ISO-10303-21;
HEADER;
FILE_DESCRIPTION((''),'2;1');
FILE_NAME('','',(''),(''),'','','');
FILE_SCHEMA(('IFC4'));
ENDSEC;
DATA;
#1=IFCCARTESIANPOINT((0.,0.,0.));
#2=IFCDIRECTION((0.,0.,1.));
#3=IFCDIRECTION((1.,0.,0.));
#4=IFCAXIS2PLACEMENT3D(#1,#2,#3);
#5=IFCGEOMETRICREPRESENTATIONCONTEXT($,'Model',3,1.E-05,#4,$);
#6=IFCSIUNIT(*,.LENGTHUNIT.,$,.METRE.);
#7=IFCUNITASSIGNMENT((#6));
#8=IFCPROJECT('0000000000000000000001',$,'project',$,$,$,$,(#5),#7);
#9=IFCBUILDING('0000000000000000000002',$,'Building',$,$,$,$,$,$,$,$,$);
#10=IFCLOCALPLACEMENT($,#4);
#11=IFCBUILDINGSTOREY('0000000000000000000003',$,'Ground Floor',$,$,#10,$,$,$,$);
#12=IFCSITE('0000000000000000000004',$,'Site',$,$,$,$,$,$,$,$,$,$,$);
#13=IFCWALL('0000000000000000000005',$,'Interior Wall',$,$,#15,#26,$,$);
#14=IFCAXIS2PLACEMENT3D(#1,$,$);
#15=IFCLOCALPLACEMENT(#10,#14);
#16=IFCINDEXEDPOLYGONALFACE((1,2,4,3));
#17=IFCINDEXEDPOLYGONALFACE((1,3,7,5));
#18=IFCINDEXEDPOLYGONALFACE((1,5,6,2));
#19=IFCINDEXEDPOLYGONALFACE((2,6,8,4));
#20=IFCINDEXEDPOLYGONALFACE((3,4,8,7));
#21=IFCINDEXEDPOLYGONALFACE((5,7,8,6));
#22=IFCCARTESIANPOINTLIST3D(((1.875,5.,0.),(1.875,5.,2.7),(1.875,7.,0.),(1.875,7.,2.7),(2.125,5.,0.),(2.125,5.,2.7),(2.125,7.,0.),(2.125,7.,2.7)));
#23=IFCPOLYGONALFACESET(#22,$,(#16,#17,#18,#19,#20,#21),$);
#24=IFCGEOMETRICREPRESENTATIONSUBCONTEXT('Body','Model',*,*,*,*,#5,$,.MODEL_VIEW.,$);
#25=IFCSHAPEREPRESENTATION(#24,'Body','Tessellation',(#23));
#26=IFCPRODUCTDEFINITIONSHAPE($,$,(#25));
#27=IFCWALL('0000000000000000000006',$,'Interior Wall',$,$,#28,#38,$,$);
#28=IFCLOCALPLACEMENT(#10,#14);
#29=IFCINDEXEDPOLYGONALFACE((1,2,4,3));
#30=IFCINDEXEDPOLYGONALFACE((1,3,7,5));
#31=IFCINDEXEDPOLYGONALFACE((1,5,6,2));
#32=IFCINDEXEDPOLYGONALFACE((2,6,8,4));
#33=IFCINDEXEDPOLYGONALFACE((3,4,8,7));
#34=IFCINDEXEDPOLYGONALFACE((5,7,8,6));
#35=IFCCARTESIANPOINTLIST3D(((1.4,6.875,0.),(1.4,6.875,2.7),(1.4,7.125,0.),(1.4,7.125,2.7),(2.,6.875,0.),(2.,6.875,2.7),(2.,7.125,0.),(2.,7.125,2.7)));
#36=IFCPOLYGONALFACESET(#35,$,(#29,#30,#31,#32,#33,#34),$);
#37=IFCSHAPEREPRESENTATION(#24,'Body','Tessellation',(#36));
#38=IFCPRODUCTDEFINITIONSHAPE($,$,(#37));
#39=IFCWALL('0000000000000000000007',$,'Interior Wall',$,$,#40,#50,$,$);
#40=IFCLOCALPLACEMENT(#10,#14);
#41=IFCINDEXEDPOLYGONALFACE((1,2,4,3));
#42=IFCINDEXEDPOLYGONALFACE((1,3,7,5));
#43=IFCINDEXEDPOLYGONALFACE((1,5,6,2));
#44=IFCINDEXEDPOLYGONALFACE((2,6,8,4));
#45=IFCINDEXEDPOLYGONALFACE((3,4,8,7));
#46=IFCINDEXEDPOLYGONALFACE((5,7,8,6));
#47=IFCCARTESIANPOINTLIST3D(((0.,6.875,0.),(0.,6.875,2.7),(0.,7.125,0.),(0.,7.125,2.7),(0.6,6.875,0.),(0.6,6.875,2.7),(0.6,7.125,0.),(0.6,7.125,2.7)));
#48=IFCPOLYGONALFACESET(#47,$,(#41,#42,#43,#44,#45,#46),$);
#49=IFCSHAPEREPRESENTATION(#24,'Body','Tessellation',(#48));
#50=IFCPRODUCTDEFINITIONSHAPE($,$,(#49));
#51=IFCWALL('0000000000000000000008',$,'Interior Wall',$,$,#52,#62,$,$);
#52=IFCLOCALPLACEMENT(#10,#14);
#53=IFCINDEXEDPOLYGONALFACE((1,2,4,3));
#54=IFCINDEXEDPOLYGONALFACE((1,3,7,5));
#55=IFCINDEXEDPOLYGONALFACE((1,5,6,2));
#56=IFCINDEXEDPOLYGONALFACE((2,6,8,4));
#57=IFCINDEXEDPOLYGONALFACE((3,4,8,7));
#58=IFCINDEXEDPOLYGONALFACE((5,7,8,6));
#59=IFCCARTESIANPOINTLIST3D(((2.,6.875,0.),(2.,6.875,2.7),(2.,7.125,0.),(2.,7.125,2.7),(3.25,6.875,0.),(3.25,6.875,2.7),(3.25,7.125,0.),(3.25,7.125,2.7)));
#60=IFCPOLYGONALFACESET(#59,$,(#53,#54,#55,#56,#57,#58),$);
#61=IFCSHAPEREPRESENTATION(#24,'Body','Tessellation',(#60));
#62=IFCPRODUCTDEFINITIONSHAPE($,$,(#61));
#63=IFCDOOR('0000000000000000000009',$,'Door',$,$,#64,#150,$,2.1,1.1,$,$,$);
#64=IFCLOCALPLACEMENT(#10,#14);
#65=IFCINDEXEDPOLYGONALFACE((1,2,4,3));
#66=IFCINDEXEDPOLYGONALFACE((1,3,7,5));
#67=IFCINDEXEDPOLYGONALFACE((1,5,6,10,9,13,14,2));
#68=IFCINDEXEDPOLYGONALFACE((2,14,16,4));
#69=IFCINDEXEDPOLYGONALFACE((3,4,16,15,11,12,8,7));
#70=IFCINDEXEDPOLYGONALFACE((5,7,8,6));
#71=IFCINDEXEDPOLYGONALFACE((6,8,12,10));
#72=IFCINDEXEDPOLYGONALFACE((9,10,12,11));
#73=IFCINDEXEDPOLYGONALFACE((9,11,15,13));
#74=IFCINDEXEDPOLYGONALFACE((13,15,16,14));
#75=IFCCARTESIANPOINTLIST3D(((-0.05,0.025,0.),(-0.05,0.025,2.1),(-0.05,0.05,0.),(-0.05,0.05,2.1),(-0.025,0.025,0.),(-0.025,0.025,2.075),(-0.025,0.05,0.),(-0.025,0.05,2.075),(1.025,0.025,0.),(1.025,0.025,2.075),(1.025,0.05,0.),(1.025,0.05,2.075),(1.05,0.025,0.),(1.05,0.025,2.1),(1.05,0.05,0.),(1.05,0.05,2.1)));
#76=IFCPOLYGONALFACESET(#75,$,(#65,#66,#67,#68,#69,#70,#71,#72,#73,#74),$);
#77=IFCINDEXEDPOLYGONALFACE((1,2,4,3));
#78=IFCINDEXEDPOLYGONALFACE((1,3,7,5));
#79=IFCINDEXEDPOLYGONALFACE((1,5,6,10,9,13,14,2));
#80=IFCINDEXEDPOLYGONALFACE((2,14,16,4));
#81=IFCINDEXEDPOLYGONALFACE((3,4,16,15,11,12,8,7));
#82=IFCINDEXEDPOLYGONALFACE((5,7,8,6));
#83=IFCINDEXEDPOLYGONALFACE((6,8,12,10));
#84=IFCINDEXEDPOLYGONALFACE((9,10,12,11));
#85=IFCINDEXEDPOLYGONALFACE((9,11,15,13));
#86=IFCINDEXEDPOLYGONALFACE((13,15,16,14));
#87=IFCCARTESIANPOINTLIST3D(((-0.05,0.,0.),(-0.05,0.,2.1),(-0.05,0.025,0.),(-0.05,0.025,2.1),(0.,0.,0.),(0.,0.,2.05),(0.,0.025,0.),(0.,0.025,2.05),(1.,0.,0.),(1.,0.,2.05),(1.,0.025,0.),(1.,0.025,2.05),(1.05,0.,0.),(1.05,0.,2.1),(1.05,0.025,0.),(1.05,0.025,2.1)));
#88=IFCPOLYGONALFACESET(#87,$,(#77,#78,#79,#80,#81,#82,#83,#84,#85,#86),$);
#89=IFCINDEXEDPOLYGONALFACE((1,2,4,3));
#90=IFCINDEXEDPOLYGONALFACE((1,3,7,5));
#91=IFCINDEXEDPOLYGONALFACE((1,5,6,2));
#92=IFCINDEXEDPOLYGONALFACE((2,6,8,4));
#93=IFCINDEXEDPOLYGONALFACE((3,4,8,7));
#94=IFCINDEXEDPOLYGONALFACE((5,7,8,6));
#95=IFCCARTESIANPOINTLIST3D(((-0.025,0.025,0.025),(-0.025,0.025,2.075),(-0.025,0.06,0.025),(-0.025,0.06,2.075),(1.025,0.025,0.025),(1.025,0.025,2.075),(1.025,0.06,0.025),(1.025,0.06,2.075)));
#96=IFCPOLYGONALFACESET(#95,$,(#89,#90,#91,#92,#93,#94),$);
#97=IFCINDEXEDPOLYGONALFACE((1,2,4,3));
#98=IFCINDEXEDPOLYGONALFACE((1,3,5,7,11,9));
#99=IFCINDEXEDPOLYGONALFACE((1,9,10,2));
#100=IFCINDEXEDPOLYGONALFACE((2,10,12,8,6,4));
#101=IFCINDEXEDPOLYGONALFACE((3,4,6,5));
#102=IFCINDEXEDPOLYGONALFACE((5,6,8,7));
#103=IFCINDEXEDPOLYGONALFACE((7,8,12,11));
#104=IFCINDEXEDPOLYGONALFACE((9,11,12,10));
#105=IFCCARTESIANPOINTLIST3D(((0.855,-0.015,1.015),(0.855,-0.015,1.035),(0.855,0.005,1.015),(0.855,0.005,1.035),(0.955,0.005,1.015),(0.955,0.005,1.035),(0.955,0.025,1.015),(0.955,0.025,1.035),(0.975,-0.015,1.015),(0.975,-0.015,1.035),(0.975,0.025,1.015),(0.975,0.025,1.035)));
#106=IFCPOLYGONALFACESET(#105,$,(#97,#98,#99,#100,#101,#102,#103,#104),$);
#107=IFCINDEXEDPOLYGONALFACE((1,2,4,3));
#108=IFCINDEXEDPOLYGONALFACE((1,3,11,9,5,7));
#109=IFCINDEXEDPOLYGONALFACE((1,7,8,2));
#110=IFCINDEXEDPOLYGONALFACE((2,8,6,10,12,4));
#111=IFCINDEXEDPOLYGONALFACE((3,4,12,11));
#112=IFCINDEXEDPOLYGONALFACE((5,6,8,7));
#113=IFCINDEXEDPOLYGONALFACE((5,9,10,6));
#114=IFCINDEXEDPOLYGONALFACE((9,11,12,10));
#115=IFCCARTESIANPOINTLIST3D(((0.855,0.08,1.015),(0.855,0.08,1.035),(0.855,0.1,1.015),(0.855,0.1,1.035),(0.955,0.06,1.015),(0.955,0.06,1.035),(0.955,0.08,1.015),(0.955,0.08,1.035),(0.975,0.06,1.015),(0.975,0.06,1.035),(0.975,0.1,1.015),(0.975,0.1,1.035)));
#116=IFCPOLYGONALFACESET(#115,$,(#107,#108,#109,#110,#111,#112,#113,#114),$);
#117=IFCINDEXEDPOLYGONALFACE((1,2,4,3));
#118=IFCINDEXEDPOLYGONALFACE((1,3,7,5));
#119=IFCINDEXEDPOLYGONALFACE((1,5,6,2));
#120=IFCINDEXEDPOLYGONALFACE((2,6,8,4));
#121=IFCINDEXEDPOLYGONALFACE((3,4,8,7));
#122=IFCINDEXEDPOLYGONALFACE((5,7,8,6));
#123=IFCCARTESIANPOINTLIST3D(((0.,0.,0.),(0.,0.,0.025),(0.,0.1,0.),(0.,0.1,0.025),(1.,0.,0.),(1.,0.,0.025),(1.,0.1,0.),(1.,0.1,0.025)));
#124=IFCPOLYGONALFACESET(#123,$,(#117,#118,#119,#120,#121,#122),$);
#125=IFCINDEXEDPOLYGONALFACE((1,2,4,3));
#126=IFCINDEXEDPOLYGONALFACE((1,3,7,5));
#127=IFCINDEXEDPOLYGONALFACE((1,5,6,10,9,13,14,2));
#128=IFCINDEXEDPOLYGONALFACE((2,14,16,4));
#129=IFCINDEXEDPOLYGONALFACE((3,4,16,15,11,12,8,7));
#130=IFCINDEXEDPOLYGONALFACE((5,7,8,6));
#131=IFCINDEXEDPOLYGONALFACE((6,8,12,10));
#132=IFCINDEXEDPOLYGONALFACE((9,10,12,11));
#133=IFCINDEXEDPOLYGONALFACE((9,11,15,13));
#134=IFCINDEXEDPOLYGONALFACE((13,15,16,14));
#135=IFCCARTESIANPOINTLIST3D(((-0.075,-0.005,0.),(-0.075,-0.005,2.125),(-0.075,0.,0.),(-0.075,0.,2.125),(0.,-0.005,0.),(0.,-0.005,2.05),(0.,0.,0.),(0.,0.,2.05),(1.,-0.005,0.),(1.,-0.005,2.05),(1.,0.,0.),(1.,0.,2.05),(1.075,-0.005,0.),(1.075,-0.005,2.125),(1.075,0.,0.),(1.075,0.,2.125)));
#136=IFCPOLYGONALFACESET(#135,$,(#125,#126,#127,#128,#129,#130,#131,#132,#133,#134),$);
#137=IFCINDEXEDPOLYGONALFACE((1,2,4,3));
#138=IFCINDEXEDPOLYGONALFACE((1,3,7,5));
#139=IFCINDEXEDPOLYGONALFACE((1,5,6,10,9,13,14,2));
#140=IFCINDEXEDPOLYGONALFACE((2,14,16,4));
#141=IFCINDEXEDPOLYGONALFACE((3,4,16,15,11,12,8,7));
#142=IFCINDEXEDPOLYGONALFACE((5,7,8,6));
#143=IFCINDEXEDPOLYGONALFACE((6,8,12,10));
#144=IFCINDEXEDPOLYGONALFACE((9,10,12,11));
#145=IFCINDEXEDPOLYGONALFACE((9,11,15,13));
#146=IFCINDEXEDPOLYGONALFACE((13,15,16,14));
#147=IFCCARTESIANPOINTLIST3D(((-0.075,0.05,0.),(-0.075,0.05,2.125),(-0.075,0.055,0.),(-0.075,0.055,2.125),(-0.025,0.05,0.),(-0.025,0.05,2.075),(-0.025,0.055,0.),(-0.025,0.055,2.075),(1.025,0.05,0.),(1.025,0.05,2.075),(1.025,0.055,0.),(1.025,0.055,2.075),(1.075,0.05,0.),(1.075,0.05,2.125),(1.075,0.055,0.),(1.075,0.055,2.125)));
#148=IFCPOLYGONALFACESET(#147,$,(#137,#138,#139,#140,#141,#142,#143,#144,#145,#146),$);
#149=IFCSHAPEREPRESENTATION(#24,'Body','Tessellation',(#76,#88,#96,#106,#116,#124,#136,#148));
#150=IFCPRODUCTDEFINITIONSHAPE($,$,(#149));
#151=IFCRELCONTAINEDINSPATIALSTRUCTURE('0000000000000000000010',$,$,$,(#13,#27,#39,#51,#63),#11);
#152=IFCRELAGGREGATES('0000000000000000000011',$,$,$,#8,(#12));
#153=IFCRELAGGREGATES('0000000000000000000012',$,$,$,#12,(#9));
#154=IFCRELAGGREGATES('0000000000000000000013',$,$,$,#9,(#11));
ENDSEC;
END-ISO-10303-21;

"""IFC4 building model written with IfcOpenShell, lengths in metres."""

from ifc_helpers import new_model, si_unit, frame, origin_with_axes, place, context, subcontext, project, spatial, line, indexed_curve, outline, extrude, element, save


model = new_model("IFC4")

# Units and contexts
model_context = context("Model", 3, precision=1e-05, world=origin_with_axes())
body_context = subcontext(model_context, "Body", "Model", "MODEL_VIEW")
ifc_project = project(units=[si_unit("LENGTHUNIT", "METRE")], contexts=[model_context])

# Site, building, storey
site = spatial("IfcSite", under=ifc_project, Name="Site")
building = spatial("IfcBuilding", under=site, Name="Building")
storey_placement = place(None, origin_with_axes())
storey = spatial("IfcBuildingStorey", under=building, at=storey_placement, Name="Ground Floor")

# Walls
wall_1_placement = place(storey_placement, frame((2.0, 5.0, 0.0), z_axis=(0.0, 0.0, 1.0), x_axis=(0.0, 1.0, 0.0)))
element("IfcWall", 1, at=wall_1_placement, inside=storey, Name="Interior Wall", context=body_context, shape_type="SweptSolid", body=[
    extrude(outline(indexed_curve([(0.0, 0.0), (0.0, 0.25), (2.0, 0.25), (2.0, 0.0), (0.0, 0.0)], self_intersect=False)), frame((0.0, -0.125, 0.0), z_axis=(0.0, 0.0, 1.0), x_axis=(1.0, 0.0, 0.0)), (0.0, 0.0, 1.0), 2.7),
])
for number, where, z_axis, x_axis, name in (
    (2, (2.0, 7.0, 0.0), (0.0, 0.0, 1.0), (-1.0, 0.0, 0.0), "Interior Wall"),
    (3, (0.6, 7.0, 0.0), (0.0, 0.0, 1.0), (-1.0, 0.0, 0.0), "Interior Wall"),
):
    element("IfcWall", number, at=place(storey_placement, frame(where, z_axis=z_axis, x_axis=x_axis)), inside=storey, Name=name, context=body_context, shape_type="SweptSolid", body=[
        extrude(outline(indexed_curve([(0.0, 0.0), (0.0, 0.25), (0.6, 0.25), (0.6, 0.0), (0.0, 0.0)], self_intersect=False)), frame((0.0, -0.125, 0.0), z_axis=(0.0, 0.0, 1.0), x_axis=(1.0, 0.0, 0.0)), (0.0, 0.0, 1.0), 2.7),
    ])
wall_2_placement = place(storey_placement, frame((3.25, 7.0, 0.0), z_axis=(0.0, 0.0, 1.0), x_axis=(-1.0, 0.0, 0.0)))
element("IfcWall", 4, at=wall_2_placement, inside=storey, Name="Interior Wall", context=body_context, shape_type="SweptSolid", body=[
    extrude(outline(indexed_curve([(0.0, 0.0), (0.0, 0.25), (1.25, 0.25), (1.25, 0.0), (0.0, 0.0)], self_intersect=False)), frame((0.0, -0.125, 0.0), z_axis=(0.0, 0.0, 1.0), x_axis=(1.0, 0.0, 0.0)), (0.0, 0.0, 1.0), 2.7),
])

# Door
door_1_placement = place(storey_placement, frame((-0.05, 0.0, 0.0), z_axis=(0.0, 0.0, 1.0), x_axis=(1.0, 0.0, 0.0)))
element("IfcDoor", 5, at=door_1_placement, inside=storey, Name="Door", OverallHeight=2.1, OverallWidth=1.1, context=body_context, shape_type="SweptSolid", body=[
    extrude(outline(indexed_curve([(0.0, 0.0), (0.0, 2.1), (1.1, 2.1), (1.1, 0.0), (1.075, 0.0), (1.075, 2.075), (0.025, 2.075), (0.025, 0.0)], segments=[line(1, 2, 3, 4, 5, 6, 7, 8, 1)])), frame((0.0, 0.025, 0.0), z_axis=(0.0, -1.0, 0.0), x_axis=(1.0, 0.0, 0.0)), (0.0, 0.0, -1.0), 0.025),
    extrude(outline(indexed_curve([(0.0, 0.0), (0.0, 2.1), (1.1, 2.1), (1.1, 0.0), (1.05, 0.0), (1.05, 2.05), (0.05, 2.05), (0.05, 0.0)], segments=[line(1, 2, 3, 4, 5, 6, 7, 8, 1)])), frame((0.0, 0.0, 0.0), z_axis=(0.0, -1.0, 0.0), x_axis=(1.0, 0.0, 0.0)), (0.0, 0.0, -1.0), 0.025),
    extrude(outline(indexed_curve([(0.0, 0.0), (1.05, 0.0), (1.05, 0.035), (0.0, 0.035)], segments=[line(1, 2, 3, 4, 1)])), frame((0.025, 0.025, 0.025), z_axis=(0.0, 0.0, 1.0), x_axis=(1.0, 0.0, 0.0)), (0.0, 0.0, 1.0), 2.05),
    extrude(outline(indexed_curve([(0.0, 0.0), (0.0, -0.04), (-0.12, -0.04), (-0.12, -0.02), (-0.02, -0.02), (-0.02, 0.0)], segments=[line(1, 2, 3, 4, 5, 6, 1)])), frame((1.025, 0.025, 1.015), z_axis=(0.0, 0.0, 1.0), x_axis=(1.0, 0.0, 0.0)), (0.0, 0.0, 1.0), 0.02),
    extrude(outline(indexed_curve([(0.0, 0.0), (0.0, 0.04), (-0.12, 0.04), (-0.12, 0.02), (-0.02, 0.02), (-0.02, 0.0)], segments=[line(1, 2, 3, 4, 5, 6, 1)])), frame((1.025, 0.06, 1.015), z_axis=(0.0, 0.0, 1.0), x_axis=(1.0, 0.0, 0.0)), (0.0, 0.0, 1.0), 0.02),
    extrude(outline(indexed_curve([(0.0, 0.0), (1.0, 0.0), (1.0, 0.1), (0.0, 0.1)], segments=[line(1, 2, 3, 4, 1)])), frame((0.05, 0.0, 0.0), z_axis=(0.0, 0.0, 1.0), x_axis=(1.0, 0.0, 0.0)), (0.0, 0.0, 1.0), 0.025),
    extrude(outline(indexed_curve([(0.0, 0.0), (0.0, 2.125), (1.15, 2.125), (1.15, 0.0), (1.075, 0.0), (1.075, 2.05), (0.075, 2.05), (0.075, 0.0)], segments=[line(1, 2, 3, 4, 5, 6, 7, 8, 1)])), frame((-0.025, -0.005, 0.0), z_axis=(0.0, -1.0, 0.0), x_axis=(1.0, 0.0, 0.0)), (0.0, 0.0, -1.0), 0.005),
    extrude(outline(indexed_curve([(0.0, 0.0), (0.0, 2.125), (1.15, 2.125), (1.15, 0.0), (1.1, 0.0), (1.1, 2.075), (0.05, 2.075), (0.05, 0.0)], segments=[line(1, 2, 3, 4, 5, 6, 7, 8, 1)])), frame((-0.025, 0.05, 0.0), z_axis=(0.0, -1.0, 0.0), x_axis=(1.0, 0.0, 0.0)), (0.0, 0.0, -1.0), 0.005),
])

save(model, "model.ifc")
